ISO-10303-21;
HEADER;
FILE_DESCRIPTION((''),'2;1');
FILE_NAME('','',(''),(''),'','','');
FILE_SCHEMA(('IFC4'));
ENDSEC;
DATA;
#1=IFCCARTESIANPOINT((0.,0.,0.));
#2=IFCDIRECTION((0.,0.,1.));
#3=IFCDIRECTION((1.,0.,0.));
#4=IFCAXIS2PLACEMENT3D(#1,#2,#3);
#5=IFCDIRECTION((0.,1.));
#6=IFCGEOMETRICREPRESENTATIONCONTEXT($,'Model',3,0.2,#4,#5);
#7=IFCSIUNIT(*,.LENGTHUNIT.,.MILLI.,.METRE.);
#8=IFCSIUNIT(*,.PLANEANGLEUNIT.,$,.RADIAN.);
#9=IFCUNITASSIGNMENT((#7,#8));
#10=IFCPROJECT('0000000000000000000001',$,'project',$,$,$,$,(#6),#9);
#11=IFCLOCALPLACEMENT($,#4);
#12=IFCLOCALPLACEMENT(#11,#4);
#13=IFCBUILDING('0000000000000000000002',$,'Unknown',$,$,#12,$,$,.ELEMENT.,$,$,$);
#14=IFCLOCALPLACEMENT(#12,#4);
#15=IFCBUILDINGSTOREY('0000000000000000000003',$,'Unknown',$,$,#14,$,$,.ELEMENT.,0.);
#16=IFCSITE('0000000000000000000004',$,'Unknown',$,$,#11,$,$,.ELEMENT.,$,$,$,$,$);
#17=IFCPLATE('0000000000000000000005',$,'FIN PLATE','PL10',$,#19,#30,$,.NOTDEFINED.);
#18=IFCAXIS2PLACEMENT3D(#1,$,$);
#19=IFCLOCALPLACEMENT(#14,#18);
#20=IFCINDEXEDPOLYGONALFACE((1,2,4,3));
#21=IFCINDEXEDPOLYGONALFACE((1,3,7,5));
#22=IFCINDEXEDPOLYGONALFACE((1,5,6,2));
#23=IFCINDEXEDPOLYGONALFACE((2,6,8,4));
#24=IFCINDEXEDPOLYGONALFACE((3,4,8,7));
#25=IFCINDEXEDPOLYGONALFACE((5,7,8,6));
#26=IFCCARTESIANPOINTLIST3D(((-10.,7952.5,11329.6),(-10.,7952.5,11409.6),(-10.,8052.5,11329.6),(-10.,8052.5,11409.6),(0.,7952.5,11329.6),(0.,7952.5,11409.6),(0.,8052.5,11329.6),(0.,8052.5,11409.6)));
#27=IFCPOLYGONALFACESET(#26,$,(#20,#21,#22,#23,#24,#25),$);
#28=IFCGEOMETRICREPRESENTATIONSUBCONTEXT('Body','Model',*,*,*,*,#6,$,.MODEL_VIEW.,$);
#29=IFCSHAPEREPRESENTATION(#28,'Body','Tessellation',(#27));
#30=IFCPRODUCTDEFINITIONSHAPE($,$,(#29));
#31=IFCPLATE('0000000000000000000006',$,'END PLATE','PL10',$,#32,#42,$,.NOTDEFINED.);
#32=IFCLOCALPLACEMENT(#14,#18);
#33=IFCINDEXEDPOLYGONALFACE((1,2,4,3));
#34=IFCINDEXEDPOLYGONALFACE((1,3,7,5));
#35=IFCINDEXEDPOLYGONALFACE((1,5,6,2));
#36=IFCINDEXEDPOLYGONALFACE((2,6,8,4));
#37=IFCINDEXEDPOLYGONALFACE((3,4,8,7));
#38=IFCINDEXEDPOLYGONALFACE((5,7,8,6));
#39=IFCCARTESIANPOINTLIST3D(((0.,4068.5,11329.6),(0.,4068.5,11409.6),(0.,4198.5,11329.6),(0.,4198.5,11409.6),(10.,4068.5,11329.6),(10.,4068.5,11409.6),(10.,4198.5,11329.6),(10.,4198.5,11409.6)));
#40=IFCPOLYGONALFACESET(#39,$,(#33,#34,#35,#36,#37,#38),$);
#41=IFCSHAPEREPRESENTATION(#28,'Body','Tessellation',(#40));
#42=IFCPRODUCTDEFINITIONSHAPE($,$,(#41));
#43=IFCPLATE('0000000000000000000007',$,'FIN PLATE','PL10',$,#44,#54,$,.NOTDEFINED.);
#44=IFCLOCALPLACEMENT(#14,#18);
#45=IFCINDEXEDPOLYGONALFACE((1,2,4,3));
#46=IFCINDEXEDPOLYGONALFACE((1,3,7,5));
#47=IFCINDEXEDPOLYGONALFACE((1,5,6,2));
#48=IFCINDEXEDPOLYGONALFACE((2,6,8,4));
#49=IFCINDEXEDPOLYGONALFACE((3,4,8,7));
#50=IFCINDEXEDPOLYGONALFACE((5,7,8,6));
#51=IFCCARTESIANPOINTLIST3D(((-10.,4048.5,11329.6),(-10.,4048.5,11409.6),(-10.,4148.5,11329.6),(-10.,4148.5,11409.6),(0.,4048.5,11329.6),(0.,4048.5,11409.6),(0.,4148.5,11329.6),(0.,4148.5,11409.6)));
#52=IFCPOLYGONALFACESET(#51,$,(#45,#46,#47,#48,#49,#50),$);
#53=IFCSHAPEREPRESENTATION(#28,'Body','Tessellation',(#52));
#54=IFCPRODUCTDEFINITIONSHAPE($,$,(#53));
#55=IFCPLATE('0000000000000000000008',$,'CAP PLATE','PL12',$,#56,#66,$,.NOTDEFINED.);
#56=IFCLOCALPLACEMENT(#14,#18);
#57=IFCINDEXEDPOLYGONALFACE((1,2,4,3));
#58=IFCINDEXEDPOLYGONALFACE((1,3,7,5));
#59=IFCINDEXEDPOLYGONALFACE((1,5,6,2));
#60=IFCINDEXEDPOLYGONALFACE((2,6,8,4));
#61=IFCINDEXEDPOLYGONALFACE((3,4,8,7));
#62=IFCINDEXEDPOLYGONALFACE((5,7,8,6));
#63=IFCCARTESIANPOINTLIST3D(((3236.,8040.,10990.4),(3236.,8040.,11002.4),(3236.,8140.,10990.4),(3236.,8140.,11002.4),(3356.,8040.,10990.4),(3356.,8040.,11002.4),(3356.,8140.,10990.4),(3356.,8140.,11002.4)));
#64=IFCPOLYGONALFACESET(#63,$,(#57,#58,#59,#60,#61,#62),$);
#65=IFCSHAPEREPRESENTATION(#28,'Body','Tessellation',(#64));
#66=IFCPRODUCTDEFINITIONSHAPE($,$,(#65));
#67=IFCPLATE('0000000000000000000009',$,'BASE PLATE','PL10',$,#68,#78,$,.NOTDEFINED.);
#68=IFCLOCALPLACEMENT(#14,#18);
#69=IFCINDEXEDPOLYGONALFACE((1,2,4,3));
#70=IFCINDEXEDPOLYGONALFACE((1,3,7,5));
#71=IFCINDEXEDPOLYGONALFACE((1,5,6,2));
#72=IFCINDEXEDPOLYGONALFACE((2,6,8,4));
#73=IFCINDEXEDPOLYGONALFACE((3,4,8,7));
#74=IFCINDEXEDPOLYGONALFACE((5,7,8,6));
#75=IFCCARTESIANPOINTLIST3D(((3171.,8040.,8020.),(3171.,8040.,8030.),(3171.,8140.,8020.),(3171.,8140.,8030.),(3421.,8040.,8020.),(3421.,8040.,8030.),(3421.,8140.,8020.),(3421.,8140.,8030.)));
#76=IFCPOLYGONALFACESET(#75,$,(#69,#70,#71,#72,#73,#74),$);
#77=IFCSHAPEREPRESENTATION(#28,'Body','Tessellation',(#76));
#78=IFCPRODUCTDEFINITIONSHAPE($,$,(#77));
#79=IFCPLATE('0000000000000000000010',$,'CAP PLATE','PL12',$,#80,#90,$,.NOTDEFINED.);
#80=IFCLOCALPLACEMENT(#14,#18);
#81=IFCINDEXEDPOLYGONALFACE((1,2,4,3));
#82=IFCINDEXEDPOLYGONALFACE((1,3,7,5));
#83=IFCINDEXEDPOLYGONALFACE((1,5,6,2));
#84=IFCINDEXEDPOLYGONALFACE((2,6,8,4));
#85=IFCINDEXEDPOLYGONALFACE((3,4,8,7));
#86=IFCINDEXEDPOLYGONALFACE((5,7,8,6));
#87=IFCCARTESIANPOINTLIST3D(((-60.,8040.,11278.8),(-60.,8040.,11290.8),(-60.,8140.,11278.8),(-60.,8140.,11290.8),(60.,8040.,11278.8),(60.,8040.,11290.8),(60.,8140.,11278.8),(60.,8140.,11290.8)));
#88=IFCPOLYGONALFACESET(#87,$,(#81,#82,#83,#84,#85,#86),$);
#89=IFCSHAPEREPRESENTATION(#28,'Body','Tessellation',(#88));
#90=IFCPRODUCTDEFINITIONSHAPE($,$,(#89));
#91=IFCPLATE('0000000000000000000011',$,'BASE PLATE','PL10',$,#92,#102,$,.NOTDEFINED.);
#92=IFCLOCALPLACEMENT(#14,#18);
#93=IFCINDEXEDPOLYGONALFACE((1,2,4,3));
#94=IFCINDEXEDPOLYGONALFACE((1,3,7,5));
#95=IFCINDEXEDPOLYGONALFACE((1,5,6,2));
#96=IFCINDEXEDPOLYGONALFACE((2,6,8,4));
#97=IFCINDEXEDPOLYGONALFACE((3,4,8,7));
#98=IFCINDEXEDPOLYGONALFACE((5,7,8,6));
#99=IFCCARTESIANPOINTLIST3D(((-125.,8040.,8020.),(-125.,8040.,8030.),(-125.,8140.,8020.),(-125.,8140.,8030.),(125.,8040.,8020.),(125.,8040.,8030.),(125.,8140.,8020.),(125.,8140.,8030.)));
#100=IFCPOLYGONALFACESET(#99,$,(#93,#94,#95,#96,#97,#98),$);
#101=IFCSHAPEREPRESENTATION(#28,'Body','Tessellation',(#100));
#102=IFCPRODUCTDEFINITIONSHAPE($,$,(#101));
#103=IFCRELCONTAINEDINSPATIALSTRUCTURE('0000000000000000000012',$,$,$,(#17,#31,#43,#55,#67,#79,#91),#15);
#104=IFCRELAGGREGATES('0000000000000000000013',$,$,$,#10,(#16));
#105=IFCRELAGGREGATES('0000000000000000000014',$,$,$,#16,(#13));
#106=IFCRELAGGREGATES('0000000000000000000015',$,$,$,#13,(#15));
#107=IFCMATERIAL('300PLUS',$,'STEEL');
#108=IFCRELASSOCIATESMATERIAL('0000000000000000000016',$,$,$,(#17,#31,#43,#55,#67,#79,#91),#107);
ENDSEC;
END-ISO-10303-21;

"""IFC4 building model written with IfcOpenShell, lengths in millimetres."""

from ifc_helpers import new_model, si_unit, direction, frame, origin_with_axes, place, context, subcontext, project, spatial, line, indexed_curve, outline, extrude, material, element, save


model = new_model("IFC4")

# Units and contexts
model_context = context("Model", 3, precision=0.2, world=origin_with_axes(), true_north=direction((0.0, 1.0)))
body_context = subcontext(model_context, "Body", "Model", "MODEL_VIEW")
ifc_project = project(units=[si_unit("LENGTHUNIT", "METRE", prefix="MILLI"), si_unit("PLANEANGLEUNIT", "RADIAN")], contexts=[model_context])

# Site, building, storey
site_placement = place(None, origin_with_axes())
site = spatial("IfcSite", under=ifc_project, at=site_placement, Name="Unknown", CompositionType="ELEMENT")
building_placement = place(site_placement, origin_with_axes())
building = spatial("IfcBuilding", under=site, at=building_placement, Name="Unknown", CompositionType="ELEMENT")
storey_placement = place(building_placement, origin_with_axes())
storey = spatial("IfcBuildingStorey", under=building, at=storey_placement, Name="Unknown", CompositionType="ELEMENT", Elevation=0.0)

# Shared definitions
ifc_material_1 = material(Name="300PLUS", Category="STEEL")

# Plates
plate_1_placement = place(storey_placement, frame((-5.0, 8052.5, 11329.6), z_axis=(-1.0, 0.0, 0.0), x_axis=(0.0, -1.0, 0.0)))
element("IfcPlate", 1, at=plate_1_placement, inside=storey, material=ifc_material_1, Name="FIN PLATE", Description="PL10", PredefinedType="NOTDEFINED", context=body_context, shape_type="SolidModel", body=[
    extrude(outline(indexed_curve([(0.0, 0.0), (100.0, 0.0), (100.0, 80.0), (0.0, 80.0)], segments=[line(1, 2, 3, 4, 1)])), frame((0.0, 0.0, 5.0), z_axis=(0.0, 0.0, 1.0), x_axis=(1.0, 0.0, 0.0)), (0.0, 0.0, -1.0), 10.0),
])
plate_2_placement = place(storey_placement, frame((5.0, 4198.5, 11409.6), z_axis=(1.0, 0.0, 0.0), x_axis=(0.0, -1.0, 0.0)))
element("IfcPlate", 2, at=plate_2_placement, inside=storey, material=ifc_material_1, Name="END PLATE", Description="PL10", PredefinedType="NOTDEFINED", context=body_context, shape_type="SolidModel", body=[
    extrude(outline(indexed_curve([(0.0, 0.0), (130.0, 0.0), (130.0, 80.0), (0.0, 80.0)], segments=[line(1, 2, 3, 4, 1)])), frame((0.0, 0.0, 5.0), z_axis=(0.0, 0.0, 1.0), x_axis=(1.0, 0.0, 0.0)), (0.0, 0.0, -1.0), 10.0),
])
plate_3_placement = place(storey_placement, frame((-5.0, 4048.5, 11409.6), z_axis=(-1.0, 0.0, 0.0), x_axis=(0.0, 1.0, 0.0)))
element("IfcPlate", 3, at=plate_3_placement, inside=storey, material=ifc_material_1, Name="FIN PLATE", Description="PL10", PredefinedType="NOTDEFINED", context=body_context, shape_type="SolidModel", body=[
    extrude(outline(indexed_curve([(0.0, 0.0), (100.0, 0.0), (100.0, 80.0), (0.0, 80.0)], segments=[line(1, 2, 3, 4, 1)])), frame((0.0, 0.0, 5.0), z_axis=(0.0, 0.0, 1.0), x_axis=(1.0, 0.0, 0.0)), (0.0, 0.0, -1.0), 10.0),
])
plate_4_placement = place(storey_placement, frame((3236.0, 8040.0, 10996.4), z_axis=(0.0, 0.0, 1.0), x_axis=(1.0, 0.0, 0.0)))
element("IfcPlate", 4, at=plate_4_placement, inside=storey, material=ifc_material_1, Name="CAP PLATE", Description="PL12", PredefinedType="NOTDEFINED", context=body_context, shape_type="SolidModel", body=[
    extrude(outline(indexed_curve([(0.0, 0.0), (120.0, 0.0), (120.0, 100.0), (0.0, 100.0)], segments=[line(1, 2, 3, 4, 1)])), frame((0.0, 0.0, 6.0), z_axis=(0.0, 0.0, 1.0), x_axis=(1.0, 0.0, 0.0)), (0.0, 0.0, -1.0), 12.0),
])
plate_5_placement = place(storey_placement, frame((3171.0, 8040.0, 8025.0), z_axis=(0.0, 0.0, 1.0), x_axis=(1.0, 0.0, 0.0)))
element("IfcPlate", 5, at=plate_5_placement, inside=storey, material=ifc_material_1, Name="BASE PLATE", Description="PL10", PredefinedType="NOTDEFINED", context=body_context, shape_type="SolidModel", body=[
    extrude(outline(indexed_curve([(0.0, 0.0), (250.0, 0.0), (250.0, 100.0), (0.0, 100.0)], segments=[line(1, 2, 3, 4, 1)])), frame((0.0, 0.0, 5.0), z_axis=(0.0, 0.0, 1.0), x_axis=(1.0, 0.0, 0.0)), (0.0, 0.0, -1.0), 10.0),
])
plate_6_placement = place(storey_placement, frame((-60.0, 8040.0, 11284.8), z_axis=(0.0, 0.0, 1.0), x_axis=(1.0, 0.0, 0.0)))
element("IfcPlate", 6, at=plate_6_placement, inside=storey, material=ifc_material_1, Name="CAP PLATE", Description="PL12", PredefinedType="NOTDEFINED", context=body_context, shape_type="SolidModel", body=[
    extrude(outline(indexed_curve([(0.0, 0.0), (120.0, 0.0), (120.0, 100.0), (0.0, 100.0)], segments=[line(1, 2, 3, 4, 1)])), frame((0.0, 0.0, 6.0), z_axis=(0.0, 0.0, 1.0), x_axis=(1.0, 0.0, 0.0)), (0.0, 0.0, -1.0), 12.0),
])
plate_7_placement = place(storey_placement, frame((-125.0, 8040.0, 8025.0), z_axis=(0.0, 0.0, 1.0), x_axis=(1.0, 0.0, 0.0)))
element("IfcPlate", 7, at=plate_7_placement, inside=storey, material=ifc_material_1, Name="BASE PLATE", Description="PL10", PredefinedType="NOTDEFINED", context=body_context, shape_type="SolidModel", body=[
    extrude(outline(indexed_curve([(0.0, 0.0), (250.0, 0.0), (250.0, 100.0), (0.0, 100.0)], segments=[line(1, 2, 3, 4, 1)])), frame((0.0, 0.0, 5.0), z_axis=(0.0, 0.0, 1.0), x_axis=(1.0, 0.0, 0.0)), (0.0, 0.0, -1.0), 10.0),
])

save(model, "model.ifc")
